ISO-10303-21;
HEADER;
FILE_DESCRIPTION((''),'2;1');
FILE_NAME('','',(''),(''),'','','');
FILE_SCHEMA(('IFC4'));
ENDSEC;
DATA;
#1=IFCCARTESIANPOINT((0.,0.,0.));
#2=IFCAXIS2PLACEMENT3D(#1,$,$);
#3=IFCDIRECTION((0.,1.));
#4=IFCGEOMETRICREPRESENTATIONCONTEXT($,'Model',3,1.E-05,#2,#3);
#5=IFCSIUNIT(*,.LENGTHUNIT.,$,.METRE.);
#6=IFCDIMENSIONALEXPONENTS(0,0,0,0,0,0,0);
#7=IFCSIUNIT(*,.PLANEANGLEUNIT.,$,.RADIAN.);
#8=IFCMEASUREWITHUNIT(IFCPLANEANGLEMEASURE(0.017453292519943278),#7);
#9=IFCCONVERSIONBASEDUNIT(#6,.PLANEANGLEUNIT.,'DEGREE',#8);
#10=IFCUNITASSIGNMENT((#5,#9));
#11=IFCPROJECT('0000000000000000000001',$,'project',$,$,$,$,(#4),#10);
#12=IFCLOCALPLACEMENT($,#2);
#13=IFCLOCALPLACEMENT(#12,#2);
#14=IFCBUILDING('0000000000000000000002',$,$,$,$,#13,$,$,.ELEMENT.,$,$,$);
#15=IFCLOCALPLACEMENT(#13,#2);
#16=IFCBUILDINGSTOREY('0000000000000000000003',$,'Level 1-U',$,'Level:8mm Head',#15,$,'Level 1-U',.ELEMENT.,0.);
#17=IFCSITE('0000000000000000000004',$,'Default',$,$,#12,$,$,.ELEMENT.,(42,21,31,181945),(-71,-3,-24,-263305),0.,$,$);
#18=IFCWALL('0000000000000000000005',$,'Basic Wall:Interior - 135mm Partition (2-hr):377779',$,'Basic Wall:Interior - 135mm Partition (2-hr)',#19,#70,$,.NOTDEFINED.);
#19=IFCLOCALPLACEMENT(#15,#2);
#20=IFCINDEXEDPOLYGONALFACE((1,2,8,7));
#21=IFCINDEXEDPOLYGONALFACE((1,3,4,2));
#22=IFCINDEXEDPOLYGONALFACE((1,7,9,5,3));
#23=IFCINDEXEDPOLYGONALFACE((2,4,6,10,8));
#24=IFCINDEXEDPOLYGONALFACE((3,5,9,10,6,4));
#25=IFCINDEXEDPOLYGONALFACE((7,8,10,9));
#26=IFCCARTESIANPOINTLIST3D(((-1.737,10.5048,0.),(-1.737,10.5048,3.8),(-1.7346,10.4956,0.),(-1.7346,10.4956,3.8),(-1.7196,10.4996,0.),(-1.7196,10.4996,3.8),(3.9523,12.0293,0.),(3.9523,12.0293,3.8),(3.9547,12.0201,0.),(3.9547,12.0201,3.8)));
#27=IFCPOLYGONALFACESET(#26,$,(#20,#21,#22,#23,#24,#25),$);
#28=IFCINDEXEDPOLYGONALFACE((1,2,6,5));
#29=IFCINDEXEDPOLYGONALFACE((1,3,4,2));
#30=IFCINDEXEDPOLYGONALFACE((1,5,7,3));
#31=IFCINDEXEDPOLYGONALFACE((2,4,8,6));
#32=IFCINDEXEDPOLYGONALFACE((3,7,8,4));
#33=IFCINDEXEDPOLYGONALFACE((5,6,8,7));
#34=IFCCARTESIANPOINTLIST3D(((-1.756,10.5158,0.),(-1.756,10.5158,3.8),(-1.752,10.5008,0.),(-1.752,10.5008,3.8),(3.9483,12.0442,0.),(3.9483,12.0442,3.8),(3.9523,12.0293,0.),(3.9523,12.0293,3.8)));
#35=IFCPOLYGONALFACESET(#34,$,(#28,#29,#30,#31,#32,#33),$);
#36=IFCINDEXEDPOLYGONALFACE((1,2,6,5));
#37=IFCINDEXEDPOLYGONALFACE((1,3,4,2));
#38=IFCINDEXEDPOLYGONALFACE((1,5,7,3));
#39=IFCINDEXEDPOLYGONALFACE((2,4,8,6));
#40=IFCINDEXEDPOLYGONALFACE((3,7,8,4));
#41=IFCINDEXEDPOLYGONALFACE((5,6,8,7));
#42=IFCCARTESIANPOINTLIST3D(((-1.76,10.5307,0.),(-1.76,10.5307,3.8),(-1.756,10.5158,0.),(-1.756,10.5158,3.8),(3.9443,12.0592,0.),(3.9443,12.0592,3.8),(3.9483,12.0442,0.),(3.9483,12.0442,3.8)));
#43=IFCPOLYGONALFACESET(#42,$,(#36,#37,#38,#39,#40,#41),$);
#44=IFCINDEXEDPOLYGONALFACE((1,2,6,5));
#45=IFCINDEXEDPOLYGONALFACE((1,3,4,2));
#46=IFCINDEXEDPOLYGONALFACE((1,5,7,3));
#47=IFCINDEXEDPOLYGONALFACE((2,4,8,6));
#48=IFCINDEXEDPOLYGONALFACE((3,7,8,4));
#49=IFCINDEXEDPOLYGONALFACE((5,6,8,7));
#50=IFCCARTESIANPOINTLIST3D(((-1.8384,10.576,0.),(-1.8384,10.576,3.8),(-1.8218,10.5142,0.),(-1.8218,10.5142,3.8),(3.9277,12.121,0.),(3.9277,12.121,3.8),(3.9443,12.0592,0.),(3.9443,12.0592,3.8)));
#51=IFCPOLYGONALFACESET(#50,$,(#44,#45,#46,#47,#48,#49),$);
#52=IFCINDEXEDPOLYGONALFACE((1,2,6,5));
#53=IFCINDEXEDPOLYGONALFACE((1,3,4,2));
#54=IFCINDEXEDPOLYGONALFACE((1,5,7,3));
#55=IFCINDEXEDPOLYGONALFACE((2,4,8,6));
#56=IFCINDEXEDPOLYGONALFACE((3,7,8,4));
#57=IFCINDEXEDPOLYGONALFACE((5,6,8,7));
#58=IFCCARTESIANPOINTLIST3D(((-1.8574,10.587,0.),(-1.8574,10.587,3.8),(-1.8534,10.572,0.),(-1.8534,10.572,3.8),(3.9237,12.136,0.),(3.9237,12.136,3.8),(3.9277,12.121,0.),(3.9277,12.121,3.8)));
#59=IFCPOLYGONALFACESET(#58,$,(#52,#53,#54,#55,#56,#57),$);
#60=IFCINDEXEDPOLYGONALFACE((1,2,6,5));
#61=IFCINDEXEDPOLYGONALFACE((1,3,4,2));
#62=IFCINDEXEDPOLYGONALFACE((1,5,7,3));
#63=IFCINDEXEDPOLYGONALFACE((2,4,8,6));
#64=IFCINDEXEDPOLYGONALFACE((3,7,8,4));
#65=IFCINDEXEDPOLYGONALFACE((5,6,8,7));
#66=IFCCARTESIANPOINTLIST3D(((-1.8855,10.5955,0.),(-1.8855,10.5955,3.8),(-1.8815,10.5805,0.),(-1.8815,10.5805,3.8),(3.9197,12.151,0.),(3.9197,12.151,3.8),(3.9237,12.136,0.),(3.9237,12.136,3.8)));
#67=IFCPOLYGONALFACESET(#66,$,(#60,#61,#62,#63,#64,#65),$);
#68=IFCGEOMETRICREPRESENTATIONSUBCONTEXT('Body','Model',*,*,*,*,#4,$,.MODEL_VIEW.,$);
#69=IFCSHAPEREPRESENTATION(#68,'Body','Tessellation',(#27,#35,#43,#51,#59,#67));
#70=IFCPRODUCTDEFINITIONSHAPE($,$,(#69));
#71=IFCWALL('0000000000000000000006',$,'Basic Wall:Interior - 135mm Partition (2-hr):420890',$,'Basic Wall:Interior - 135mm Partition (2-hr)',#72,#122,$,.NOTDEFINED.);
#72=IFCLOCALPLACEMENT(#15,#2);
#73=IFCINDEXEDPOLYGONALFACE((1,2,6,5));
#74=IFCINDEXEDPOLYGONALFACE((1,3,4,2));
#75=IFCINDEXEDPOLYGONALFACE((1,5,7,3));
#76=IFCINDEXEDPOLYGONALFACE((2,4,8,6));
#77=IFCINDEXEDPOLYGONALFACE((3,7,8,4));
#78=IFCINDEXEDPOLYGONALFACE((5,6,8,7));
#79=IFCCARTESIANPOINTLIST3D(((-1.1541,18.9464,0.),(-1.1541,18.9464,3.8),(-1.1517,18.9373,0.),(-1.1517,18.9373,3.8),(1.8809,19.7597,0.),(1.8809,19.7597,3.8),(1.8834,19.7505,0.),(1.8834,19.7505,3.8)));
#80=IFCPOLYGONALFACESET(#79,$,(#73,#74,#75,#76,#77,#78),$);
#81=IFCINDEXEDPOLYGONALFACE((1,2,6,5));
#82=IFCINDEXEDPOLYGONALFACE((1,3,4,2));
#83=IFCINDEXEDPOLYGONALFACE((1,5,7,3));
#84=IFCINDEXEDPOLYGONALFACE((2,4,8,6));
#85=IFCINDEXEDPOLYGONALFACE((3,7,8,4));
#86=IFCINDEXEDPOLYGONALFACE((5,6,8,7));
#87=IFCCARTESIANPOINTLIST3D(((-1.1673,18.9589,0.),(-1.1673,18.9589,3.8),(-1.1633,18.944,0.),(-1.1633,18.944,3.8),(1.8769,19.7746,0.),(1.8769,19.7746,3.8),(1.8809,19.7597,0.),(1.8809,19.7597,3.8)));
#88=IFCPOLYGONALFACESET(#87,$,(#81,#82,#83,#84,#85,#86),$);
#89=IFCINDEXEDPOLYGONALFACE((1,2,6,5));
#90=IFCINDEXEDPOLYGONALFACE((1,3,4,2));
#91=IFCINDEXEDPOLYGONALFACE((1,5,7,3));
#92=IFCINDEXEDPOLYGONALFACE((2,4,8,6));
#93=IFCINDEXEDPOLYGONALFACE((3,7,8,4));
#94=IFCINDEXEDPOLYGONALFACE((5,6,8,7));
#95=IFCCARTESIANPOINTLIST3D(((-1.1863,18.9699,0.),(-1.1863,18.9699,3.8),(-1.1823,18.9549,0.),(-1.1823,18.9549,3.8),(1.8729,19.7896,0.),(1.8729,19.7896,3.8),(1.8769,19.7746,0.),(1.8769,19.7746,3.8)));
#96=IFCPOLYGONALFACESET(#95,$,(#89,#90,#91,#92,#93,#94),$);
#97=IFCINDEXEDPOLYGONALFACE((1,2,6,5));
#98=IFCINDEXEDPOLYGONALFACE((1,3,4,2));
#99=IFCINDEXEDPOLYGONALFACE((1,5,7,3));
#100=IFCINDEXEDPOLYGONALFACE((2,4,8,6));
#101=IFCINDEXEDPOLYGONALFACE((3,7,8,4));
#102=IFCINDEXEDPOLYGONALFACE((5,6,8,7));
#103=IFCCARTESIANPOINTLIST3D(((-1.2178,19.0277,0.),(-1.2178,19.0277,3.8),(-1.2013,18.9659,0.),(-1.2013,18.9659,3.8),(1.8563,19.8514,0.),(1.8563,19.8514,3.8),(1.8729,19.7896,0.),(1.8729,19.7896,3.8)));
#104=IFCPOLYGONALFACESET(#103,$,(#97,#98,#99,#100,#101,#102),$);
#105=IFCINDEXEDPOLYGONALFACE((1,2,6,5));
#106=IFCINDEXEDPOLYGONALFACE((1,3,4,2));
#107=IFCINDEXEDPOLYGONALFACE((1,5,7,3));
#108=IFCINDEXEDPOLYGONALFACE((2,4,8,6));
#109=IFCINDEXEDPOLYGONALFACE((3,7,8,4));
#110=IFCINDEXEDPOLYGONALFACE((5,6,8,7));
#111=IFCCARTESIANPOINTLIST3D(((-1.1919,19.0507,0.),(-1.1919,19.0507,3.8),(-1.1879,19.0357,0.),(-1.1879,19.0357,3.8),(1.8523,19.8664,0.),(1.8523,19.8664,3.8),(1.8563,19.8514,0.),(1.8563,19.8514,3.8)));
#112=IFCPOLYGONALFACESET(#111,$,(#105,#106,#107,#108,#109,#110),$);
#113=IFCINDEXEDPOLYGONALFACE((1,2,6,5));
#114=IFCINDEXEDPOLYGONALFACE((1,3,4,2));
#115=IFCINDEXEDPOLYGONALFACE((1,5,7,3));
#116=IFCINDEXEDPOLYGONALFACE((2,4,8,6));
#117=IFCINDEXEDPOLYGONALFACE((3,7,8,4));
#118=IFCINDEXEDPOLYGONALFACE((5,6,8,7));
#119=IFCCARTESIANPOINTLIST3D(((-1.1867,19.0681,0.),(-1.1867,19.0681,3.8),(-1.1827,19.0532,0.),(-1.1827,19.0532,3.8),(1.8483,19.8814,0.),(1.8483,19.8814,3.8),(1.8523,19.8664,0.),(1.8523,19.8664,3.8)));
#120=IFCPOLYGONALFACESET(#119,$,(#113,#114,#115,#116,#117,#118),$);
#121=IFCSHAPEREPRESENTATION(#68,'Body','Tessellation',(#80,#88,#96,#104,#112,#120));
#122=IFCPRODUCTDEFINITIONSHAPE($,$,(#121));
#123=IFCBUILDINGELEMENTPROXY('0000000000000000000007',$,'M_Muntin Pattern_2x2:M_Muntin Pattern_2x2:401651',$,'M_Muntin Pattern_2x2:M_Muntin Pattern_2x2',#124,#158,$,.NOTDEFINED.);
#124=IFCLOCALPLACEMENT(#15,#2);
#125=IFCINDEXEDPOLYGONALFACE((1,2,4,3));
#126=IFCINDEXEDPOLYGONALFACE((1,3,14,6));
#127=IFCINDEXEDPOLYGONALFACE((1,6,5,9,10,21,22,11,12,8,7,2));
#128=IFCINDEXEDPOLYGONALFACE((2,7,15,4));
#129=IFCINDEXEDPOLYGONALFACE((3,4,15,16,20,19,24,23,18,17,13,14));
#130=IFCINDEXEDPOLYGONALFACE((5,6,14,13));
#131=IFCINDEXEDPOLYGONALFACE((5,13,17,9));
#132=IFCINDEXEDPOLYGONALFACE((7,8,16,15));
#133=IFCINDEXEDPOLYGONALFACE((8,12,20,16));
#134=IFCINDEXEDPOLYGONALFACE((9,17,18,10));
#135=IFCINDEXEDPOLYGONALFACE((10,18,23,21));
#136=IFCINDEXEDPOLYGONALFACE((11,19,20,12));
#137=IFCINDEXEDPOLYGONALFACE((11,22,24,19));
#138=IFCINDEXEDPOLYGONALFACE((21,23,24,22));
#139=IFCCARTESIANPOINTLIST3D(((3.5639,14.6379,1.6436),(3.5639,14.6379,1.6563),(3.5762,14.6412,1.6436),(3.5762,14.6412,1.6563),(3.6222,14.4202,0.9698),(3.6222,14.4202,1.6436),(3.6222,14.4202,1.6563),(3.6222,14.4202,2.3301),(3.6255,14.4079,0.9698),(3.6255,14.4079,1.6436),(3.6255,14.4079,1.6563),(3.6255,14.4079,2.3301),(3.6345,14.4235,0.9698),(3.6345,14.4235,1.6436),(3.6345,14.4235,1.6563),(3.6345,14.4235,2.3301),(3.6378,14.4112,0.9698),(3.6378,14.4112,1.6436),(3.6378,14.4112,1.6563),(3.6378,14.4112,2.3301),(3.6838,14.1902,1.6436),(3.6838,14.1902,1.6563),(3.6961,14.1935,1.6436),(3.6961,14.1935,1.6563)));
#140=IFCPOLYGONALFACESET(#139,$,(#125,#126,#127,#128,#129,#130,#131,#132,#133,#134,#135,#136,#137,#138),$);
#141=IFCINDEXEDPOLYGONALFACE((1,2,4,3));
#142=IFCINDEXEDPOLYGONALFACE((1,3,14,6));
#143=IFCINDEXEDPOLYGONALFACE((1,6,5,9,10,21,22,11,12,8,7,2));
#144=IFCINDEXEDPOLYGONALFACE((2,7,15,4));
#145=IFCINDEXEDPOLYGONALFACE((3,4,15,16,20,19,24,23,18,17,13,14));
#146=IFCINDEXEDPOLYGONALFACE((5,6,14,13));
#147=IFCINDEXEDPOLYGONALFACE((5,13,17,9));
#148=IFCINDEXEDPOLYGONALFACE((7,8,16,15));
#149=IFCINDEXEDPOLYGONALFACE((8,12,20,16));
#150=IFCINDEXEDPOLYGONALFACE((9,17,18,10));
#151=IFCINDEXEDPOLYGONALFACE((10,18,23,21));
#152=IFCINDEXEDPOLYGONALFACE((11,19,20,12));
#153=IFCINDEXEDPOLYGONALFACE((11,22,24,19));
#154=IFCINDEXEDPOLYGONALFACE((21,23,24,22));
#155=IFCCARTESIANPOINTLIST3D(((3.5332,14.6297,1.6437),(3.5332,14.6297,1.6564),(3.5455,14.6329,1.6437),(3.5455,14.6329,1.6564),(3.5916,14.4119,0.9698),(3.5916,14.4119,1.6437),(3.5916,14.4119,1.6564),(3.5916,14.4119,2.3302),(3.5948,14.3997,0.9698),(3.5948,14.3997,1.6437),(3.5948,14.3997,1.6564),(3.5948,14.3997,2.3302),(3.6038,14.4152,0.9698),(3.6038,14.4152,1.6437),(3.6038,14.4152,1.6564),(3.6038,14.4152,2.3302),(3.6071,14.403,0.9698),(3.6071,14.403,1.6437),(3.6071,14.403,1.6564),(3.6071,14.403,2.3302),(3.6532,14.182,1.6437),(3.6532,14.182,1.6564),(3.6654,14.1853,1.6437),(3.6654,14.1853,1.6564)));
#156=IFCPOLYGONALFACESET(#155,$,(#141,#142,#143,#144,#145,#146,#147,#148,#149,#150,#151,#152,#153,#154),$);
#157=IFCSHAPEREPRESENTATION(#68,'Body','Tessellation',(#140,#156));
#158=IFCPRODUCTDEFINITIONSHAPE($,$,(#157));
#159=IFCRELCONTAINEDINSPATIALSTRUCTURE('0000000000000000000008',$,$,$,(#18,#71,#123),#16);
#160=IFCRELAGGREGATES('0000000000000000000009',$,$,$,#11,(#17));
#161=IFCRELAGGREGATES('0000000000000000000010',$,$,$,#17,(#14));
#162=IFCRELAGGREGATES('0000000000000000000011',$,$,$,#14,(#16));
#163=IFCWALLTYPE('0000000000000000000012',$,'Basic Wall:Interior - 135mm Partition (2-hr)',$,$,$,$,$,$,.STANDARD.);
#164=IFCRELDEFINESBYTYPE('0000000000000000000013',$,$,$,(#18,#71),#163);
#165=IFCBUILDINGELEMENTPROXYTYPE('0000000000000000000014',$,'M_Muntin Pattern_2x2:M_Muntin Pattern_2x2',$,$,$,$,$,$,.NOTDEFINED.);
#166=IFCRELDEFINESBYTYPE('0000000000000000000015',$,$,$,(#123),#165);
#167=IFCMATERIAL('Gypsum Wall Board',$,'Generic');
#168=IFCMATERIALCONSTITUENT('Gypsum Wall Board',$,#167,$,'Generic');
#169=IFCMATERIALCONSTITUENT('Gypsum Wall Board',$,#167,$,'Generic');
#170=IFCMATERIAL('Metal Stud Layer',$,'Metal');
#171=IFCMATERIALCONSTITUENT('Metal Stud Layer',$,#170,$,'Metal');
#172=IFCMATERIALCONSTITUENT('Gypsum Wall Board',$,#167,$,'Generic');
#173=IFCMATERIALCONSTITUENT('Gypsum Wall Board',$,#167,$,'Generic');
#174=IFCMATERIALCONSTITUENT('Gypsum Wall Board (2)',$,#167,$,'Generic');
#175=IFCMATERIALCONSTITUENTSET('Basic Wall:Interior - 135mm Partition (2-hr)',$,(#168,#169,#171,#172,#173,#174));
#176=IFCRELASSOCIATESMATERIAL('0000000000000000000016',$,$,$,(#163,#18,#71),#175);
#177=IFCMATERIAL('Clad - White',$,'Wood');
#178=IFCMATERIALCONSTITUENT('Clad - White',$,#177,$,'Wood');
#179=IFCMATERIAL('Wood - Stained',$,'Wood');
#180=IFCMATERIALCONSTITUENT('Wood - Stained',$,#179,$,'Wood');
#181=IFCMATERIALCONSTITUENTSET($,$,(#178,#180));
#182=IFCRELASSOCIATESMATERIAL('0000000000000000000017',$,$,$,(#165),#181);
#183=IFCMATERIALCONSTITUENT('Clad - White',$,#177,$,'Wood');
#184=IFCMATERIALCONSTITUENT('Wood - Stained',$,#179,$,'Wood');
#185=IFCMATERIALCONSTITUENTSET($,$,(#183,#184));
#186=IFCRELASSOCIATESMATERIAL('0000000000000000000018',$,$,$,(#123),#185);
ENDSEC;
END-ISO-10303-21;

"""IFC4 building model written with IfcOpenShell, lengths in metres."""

from ifc_helpers import new_model, entity, si_unit, converted_unit, direction, frame, origin, place, context, subcontext, project, spatial, indexed_curve, outline, extrude, source, transform, mapped, material, constituent, constituent_set, type_object, type_shapes, element, save


model = new_model("IFC4")

# Units and contexts
model_context = context("Model", 3, precision=1e-05, world=origin(), true_north=direction((0.0, 1.0)))
body_context = subcontext(model_context, "Body", "Model", "MODEL_VIEW")
ifc_project = project(units=[si_unit("LENGTHUNIT", "METRE"), converted_unit("PLANEANGLEUNIT", "DEGREE", entity("IfcPlaneAngleMeasure", 0.017453292519943278), si_unit("PLANEANGLEUNIT", "RADIAN"), dimensions=[0, 0, 0, 0, 0, 0, 0])], contexts=[model_context])

# Site, building, storey
site_placement = place(None, origin())
site = spatial("IfcSite", under=ifc_project, at=site_placement, Name="Default", CompositionType="ELEMENT", RefLatitude=(42, 21, 31, 181945), RefLongitude=(-71, -3, -24, -263305), RefElevation=0.0)
building_placement = place(site_placement, origin())
building = spatial("IfcBuilding", under=site, at=building_placement, CompositionType="ELEMENT")
storey_placement = place(building_placement, origin())
storey = spatial("IfcBuildingStorey", under=building, at=storey_placement, Name="Level 1-U", ObjectType="Level:8mm Head", LongName="Level 1-U", CompositionType="ELEMENT", Elevation=0.0)

# Shared definitions
ifc_material_1 = material(Name="Gypsum Wall Board", Category="Generic")
ifc_constituent_1 = constituent(ifc_material_1, Name="Gypsum Wall Board", Category="Generic")
ifc_constituent_2 = constituent(ifc_material_1, Name="Gypsum Wall Board", Category="Generic")
ifc_material_2 = material(Name="Metal Stud Layer", Category="Metal")
ifc_constituent_3 = constituent(ifc_material_2, Name="Metal Stud Layer", Category="Metal")
ifc_constituent_4 = constituent(ifc_material_1, Name="Gypsum Wall Board", Category="Generic")
ifc_constituent_5 = constituent(ifc_material_1, Name="Gypsum Wall Board", Category="Generic")
ifc_constituent_6 = constituent(ifc_material_1, Name="Gypsum Wall Board (2)", Category="Generic")
ifc_constituent_set_1 = constituent_set(constituents=[ifc_constituent_1, ifc_constituent_2, ifc_constituent_3, ifc_constituent_4, ifc_constituent_5, ifc_constituent_6], Name="Basic Wall:Interior - 135mm Partition (2-hr)")
wall_type = type_object("IfcWallType", Name="Basic Wall:Interior - 135mm Partition (2-hr)", PredefinedType="STANDARD", material=ifc_constituent_set_1)

# Walls
wall_1_placement = place(storey_placement, frame((-1.868, 10.53, 0.0), z_axis=(0.0, 0.0, 1.0), x_axis=(0.965926, 0.258819, 0.0)))
element("IfcWall", 1, at=wall_1_placement, inside=storey, type_object=wall_type, material=ifc_constituent_set_1, Name="Basic Wall:Interior - 135mm Partition (2-hr):377779", ObjectType="Basic Wall:Interior - 135mm Partition (2-hr)", PredefinedType="NOTDEFINED", context=body_context, shape_type="SweptSolid", body=[
    extrude(outline(indexed_curve([(-2.3436, -0.0038), (3.5309, -0.0038), (3.5309, 0.0057), (-2.3591, 0.0057), (-2.3591, -0.0038), (-2.3436, -0.0038)], self_intersect=False)), frame((2.4791, -0.0639, 0.0)), (0.0, 0.0, 1.0), 3.8),
    extrude(outline(indexed_curve([(-2.9527, -0.0077), (2.9527, -0.0078), (2.9527, 0.0077), (-2.9527, 0.0078), (-2.9527, -0.0077)], self_intersect=False)), frame((3.0572, -0.0505, 0.0)), (0.0, 0.0, 1.0), 3.8),
    extrude(outline(indexed_curve([(-2.9527, -0.0077), (2.9527, -0.0078), (2.9527, 0.0077), (-2.9527, 0.0078), (-2.9527, -0.0077)], self_intersect=False)), frame((3.0572, -0.035, 0.0)), (0.0, 0.0, 1.0), 3.8),
    extrude(outline(indexed_curve([(-2.9847, -0.032), (2.9847, -0.032), (2.9847, 0.032), (-2.9847, 0.032), (-2.9847, -0.032)], self_intersect=False)), frame((3.0252, 0.0048, 0.0)), (0.0, 0.0, 1.0), 3.8),
    extrude(outline(indexed_curve([(-2.9925, -0.0078), (2.9925, -0.0077), (2.9925, 0.0078), (-2.9925, 0.0077), (-2.9925, -0.0078)], self_intersect=False)), frame((3.0175, 0.0445, 0.0)), (0.0, 0.0, 1.0), 3.8),
    extrude(outline(indexed_curve([(-0.0078, -3.005), (0.0077, -3.005), (0.0078, 3.005), (-0.0077, 3.005), (-0.0078, -3.005)], self_intersect=False)), frame((3.005, 0.06, 0.0), z_axis=(0.0, 0.0, 1.0), x_axis=(0.0, -1.0, 0.0)), (0.0, 0.0, 1.0), 3.8),
])
wall_2_placement = place(storey_placement, frame((-1.1692, 19.0027, 0.0), z_axis=(0.0, 0.0, 1.0), x_axis=(0.965926, 0.258819, 0.0)))
element("IfcWall", 2, at=wall_2_placement, inside=storey, type_object=wall_type, material=ifc_constituent_set_1, Name="Basic Wall:Interior - 135mm Partition (2-hr):420890", ObjectType="Basic Wall:Interior - 135mm Partition (2-hr)", PredefinedType="NOTDEFINED", context=body_context, shape_type="SweptSolid", body=[
    extrude(outline(indexed_curve([(-0.0048, -1.5711), (0.0047, -1.5711), (0.0048, 1.5711), (-0.0047, 1.5711), (-0.0048, -1.5711)], self_intersect=False)), frame((1.5711, -0.063, 0.0), z_axis=(0.0, 0.0, 1.0), x_axis=(0.0, 1.0, 0.0)), (0.0, 0.0, 1.0), 3.8),
    extrude(outline(indexed_curve([(-1.5758, -0.0077), (1.5758, -0.0078), (1.5758, 0.0077), (-1.5758, 0.0078), (-1.5758, -0.0077)], self_intersect=False)), frame((1.5663, -0.0505, 0.0)), (0.0, 0.0, 1.0), 3.8),
    extrude(outline(indexed_curve([(-1.5836, -0.0077), (1.5836, -0.0078), (1.5836, 0.0077), (-1.5836, 0.0078), (-1.5836, -0.0077)], self_intersect=False)), frame((1.5586, -0.035, 0.0)), (0.0, 0.0, 1.0), 3.8),
    extrude(outline(indexed_curve([(-1.5913, -0.032), (1.5913, -0.032), (1.5913, 0.032), (-1.5913, 0.032), (-1.5913, -0.032)], self_intersect=False)), frame((1.5508, 0.0048, 0.0)), (0.0, 0.0, 1.0), 3.8),
    extrude(outline(indexed_curve([(-1.5758, -0.0078), (1.5758, -0.0077), (1.5758, 0.0078), (-1.5758, 0.0077), (-1.5758, -0.0078)], self_intersect=False)), frame((1.5663, 0.0445, 0.0)), (0.0, 0.0, 1.0), 3.8),
    extrude(outline(indexed_curve([(-0.0077, -1.5711), (0.0078, -1.5711), (0.0077, 1.5711), (-0.0078, 1.5711), (-0.0077, -1.5711)], self_intersect=False)), frame((1.5711, 0.06, 0.0), z_axis=(0.0, 0.0, 1.0), x_axis=(0.0, -1.0, 0.0)), (0.0, 0.0, 1.0), 3.8),
])

# Building element proxy
ifc_material_3 = material(Name="Clad - White", Category="Wood")
ifc_constituent_7 = constituent(ifc_material_3, Name="Clad - White", Category="Wood")
ifc_material_4 = material(Name="Wood - Stained", Category="Wood")
ifc_constituent_8 = constituent(ifc_material_4, Name="Wood - Stained", Category="Wood")
ifc_constituent_set_2 = constituent_set(constituents=[ifc_constituent_7, ifc_constituent_8])
ifc_constituent_9 = constituent(ifc_material_3, Name="Clad - White", Category="Wood")
ifc_constituent_10 = constituent(ifc_material_4, Name="Wood - Stained", Category="Wood")
ifc_constituent_set_3 = constituent_set(constituents=[ifc_constituent_9, ifc_constituent_10])
building_element_proxy_type_1 = type_object("IfcBuildingElementProxyType", Name="M_Muntin Pattern_2x2:M_Muntin Pattern_2x2", PredefinedType="NOTDEFINED", material=ifc_constituent_set_3)
shared_shape_1 = source(origin(), body_context, "Body", "SweptSolid", [
    extrude(outline(indexed_curve([(0.0064, -0.0064), (0.6801, -0.0064), (0.6801, 0.0063), (0.0064, 0.0063), (0.0064, 0.2317), (-0.0063, 0.2317), (-0.0063, 0.0063), (-0.6802, 0.0063), (-0.6802, -0.0064), (-0.0063, -0.0064), (-0.0063, -0.2317), (0.0064, -0.2317), (0.0064, -0.0064)], self_intersect=False)), frame((0.0, 0.0095, 0.6801), z_axis=(0.0, 1.0, 0.0), x_axis=(0.0, 0.0, 1.0)), (0.0, 0.0, 1.0), 0.0127),
    extrude(outline(indexed_curve([(0.0064, -0.0064), (0.6802, -0.0064), (0.6802, 0.0063), (0.0064, 0.0063), (0.0064, 0.2317), (-0.0063, 0.2317), (-0.0063, 0.0063), (-0.6802, 0.0063), (-0.6802, -0.0064), (-0.0063, -0.0064), (-0.0063, -0.2317), (0.0064, -0.2317), (0.0064, -0.0064)], self_intersect=False)), frame((0.0, -0.0222, 0.6802), z_axis=(0.0, 1.0, 0.0), x_axis=(0.0, 0.0, 1.0)), (0.0, 0.0, 1.0), 0.0127),
])
type_shapes(building_element_proxy_type_1, [shared_shape_1])
proxy_1_placement = place(storey_placement, frame((3.6147, 14.4116, 0.9698), z_axis=(0.0, 0.0, 1.0), x_axis=(0.258819, -0.965926, 0.0)))
element("IfcBuildingElementProxy", 3, at=proxy_1_placement, inside=storey, type_object=building_element_proxy_type_1, material=ifc_constituent_set_2, Name="M_Muntin Pattern_2x2:M_Muntin Pattern_2x2:401651", ObjectType="M_Muntin Pattern_2x2:M_Muntin Pattern_2x2", PredefinedType="NOTDEFINED", context=body_context, shape_type="MappedRepresentation", body=[
    mapped(shared_shape_1, transform((0.0, 0.0, 0.0), scale=1.0)),
])

save(model, "model.ifc")
